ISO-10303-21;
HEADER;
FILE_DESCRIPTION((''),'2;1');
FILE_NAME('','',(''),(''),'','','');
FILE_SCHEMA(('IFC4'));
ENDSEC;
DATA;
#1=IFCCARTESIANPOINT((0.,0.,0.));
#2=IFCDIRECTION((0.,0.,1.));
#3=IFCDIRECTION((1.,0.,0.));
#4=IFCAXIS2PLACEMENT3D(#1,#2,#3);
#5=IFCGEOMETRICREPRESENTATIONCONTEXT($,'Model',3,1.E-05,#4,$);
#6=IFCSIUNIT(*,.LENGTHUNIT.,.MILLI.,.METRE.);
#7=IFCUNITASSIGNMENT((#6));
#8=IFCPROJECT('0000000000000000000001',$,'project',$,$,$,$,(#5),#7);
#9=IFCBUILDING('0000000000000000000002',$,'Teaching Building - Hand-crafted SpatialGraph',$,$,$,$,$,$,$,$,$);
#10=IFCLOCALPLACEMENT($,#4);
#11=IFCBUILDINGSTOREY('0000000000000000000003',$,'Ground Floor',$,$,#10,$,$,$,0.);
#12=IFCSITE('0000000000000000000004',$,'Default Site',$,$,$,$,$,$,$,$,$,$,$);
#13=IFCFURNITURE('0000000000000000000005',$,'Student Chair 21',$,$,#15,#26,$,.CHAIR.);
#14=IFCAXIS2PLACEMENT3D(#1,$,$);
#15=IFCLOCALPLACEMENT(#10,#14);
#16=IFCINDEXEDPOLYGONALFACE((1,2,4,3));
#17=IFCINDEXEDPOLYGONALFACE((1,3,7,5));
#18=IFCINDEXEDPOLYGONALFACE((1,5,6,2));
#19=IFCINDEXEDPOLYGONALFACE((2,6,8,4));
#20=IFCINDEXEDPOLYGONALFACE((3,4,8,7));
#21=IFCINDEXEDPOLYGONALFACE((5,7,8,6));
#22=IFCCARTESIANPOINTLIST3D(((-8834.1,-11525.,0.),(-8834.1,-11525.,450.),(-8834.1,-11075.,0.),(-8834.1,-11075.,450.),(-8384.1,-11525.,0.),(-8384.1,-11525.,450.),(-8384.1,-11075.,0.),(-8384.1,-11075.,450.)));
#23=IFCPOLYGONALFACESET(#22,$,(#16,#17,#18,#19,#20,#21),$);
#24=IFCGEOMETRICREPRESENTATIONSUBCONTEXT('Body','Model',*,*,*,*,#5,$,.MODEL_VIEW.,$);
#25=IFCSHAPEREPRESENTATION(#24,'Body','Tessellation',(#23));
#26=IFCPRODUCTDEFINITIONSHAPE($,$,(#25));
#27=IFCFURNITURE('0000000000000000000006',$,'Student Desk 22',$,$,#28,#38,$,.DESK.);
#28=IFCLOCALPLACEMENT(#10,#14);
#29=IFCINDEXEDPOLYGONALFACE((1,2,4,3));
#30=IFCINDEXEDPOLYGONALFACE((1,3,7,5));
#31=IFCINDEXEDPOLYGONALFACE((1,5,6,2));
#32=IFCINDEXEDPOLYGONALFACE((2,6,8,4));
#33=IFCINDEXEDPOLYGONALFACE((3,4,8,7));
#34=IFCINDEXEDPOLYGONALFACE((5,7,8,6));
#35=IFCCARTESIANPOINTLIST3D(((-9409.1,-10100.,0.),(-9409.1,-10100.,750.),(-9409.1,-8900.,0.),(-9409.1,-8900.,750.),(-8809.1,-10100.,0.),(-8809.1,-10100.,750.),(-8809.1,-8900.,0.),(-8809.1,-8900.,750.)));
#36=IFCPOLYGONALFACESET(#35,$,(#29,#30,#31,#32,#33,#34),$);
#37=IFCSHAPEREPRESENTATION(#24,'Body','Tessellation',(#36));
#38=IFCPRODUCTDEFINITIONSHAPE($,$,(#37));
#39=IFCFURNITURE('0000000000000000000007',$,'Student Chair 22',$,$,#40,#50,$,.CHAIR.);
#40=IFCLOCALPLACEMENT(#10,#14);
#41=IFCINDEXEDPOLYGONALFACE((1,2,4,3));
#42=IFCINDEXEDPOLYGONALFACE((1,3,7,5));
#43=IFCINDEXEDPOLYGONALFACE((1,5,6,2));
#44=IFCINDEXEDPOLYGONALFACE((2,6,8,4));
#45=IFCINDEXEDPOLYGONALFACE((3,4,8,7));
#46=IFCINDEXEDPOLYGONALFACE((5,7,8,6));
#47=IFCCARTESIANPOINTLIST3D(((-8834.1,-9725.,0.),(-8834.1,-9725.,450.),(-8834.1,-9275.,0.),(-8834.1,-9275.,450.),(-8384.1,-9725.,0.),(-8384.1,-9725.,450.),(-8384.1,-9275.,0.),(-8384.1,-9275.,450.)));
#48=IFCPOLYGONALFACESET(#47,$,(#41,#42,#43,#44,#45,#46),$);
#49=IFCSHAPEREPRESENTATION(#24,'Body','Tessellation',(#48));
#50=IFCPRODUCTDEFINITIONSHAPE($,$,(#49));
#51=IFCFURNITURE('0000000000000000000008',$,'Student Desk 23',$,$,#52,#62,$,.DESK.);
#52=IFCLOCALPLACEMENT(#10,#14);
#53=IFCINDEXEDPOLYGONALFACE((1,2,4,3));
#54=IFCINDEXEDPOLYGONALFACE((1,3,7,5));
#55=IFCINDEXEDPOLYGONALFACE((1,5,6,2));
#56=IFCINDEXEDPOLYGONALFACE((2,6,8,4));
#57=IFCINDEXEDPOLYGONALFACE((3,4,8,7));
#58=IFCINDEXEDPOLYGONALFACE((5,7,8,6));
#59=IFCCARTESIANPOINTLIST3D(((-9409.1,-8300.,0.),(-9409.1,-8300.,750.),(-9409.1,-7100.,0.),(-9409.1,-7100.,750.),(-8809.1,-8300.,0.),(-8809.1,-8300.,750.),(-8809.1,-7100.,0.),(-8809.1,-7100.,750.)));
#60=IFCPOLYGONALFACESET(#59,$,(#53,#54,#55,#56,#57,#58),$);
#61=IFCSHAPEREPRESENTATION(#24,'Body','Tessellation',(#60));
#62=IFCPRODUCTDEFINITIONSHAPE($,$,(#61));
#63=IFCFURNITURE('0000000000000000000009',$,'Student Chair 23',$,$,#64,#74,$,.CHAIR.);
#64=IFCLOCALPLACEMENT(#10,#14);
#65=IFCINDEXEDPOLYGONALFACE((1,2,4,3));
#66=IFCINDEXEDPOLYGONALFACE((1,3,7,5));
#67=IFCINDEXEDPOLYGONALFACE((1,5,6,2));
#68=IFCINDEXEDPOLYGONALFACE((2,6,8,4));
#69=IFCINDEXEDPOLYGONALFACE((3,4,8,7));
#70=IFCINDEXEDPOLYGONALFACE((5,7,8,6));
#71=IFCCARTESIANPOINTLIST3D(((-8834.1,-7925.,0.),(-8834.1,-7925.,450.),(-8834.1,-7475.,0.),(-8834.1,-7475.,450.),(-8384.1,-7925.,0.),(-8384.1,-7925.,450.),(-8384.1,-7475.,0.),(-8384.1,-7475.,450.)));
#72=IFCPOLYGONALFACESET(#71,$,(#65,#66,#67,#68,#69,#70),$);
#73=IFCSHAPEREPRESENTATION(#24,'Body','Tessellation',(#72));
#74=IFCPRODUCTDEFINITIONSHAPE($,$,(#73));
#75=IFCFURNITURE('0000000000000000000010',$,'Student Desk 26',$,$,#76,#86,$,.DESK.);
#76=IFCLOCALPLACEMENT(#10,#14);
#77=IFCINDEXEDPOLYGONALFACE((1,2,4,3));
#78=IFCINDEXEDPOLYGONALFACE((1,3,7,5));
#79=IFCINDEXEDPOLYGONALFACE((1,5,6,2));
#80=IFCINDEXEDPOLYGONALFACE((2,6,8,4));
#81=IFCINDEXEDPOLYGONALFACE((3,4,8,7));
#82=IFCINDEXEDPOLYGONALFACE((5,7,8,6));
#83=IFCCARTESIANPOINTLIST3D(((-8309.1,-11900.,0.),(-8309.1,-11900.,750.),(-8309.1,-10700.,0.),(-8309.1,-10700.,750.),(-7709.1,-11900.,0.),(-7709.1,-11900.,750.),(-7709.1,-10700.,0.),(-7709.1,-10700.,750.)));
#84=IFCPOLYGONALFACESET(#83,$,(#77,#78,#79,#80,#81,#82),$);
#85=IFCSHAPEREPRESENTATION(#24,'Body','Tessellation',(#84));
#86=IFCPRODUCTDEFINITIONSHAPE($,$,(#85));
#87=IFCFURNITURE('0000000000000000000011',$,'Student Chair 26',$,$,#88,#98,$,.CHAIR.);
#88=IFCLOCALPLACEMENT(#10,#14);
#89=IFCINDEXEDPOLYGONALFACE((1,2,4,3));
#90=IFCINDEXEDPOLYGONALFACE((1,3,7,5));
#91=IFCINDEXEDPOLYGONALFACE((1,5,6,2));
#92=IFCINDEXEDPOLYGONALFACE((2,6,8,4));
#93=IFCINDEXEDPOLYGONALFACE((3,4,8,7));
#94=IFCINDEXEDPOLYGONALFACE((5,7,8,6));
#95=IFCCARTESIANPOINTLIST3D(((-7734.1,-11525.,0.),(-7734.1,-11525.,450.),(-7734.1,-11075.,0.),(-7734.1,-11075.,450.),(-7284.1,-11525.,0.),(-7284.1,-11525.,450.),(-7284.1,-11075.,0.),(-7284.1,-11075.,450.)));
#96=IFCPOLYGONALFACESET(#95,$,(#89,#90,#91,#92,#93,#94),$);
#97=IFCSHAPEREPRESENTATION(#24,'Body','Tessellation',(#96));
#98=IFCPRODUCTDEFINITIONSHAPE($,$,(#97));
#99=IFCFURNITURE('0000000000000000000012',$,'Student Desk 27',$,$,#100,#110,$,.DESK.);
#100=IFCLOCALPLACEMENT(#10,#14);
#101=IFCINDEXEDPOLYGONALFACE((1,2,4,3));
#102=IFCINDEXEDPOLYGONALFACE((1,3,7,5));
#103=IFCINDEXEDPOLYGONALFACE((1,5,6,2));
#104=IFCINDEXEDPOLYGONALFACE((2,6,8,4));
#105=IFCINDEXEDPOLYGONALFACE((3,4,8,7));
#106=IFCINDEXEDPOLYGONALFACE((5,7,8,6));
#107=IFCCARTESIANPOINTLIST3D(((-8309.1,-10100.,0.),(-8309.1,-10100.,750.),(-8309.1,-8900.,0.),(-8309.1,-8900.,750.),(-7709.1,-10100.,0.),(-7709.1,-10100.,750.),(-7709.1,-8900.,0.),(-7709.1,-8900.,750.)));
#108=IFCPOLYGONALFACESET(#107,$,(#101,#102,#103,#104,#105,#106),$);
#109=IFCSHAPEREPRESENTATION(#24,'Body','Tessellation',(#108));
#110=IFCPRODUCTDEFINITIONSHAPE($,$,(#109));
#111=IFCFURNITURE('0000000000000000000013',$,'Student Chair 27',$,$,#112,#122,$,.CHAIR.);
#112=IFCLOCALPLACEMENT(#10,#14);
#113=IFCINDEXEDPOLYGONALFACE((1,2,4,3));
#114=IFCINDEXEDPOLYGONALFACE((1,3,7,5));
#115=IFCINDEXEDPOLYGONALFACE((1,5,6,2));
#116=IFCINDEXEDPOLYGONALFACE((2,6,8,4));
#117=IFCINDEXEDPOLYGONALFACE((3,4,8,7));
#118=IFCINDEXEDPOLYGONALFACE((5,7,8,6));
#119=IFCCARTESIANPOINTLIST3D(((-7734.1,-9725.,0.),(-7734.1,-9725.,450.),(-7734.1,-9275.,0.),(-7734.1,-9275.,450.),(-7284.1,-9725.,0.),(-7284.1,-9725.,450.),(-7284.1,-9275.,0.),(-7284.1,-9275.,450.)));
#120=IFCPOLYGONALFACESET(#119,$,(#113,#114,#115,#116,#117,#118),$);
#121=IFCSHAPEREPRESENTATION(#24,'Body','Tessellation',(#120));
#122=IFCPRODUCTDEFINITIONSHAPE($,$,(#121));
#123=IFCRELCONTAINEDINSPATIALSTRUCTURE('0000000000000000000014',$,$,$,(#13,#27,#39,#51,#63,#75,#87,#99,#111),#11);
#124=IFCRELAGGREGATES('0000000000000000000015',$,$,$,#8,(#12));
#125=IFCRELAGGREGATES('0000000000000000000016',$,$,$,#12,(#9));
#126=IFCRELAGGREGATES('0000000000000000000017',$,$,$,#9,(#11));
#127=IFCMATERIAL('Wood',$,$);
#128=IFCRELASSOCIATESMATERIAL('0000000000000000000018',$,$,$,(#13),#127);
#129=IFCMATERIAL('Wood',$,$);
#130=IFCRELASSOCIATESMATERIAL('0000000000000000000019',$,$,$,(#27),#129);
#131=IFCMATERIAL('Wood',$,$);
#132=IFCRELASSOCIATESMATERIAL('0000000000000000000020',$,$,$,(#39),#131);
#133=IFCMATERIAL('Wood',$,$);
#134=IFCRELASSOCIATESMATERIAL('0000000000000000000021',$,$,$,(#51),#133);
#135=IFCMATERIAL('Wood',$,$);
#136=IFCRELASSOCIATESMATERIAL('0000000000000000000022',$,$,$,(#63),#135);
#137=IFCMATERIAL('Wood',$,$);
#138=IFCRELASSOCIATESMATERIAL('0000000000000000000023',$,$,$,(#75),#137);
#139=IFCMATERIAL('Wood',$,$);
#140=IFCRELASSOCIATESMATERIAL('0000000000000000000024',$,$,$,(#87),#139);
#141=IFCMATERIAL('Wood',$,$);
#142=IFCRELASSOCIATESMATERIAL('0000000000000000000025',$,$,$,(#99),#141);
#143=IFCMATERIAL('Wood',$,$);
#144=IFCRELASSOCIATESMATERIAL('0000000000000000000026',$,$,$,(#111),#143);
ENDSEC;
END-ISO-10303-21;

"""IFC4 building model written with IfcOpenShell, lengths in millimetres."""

from ifc_helpers import new_model, si_unit, frame, origin_with_axes, origin_2d, place, context, subcontext, project, spatial, rectangle, extrude, material, element, save


model = new_model("IFC4")

# Units and contexts
model_context = context("Model", 3, precision=1e-05, world=origin_with_axes())
body_context = subcontext(model_context, "Body", "Model", "MODEL_VIEW")
ifc_project = project(units=[si_unit("LENGTHUNIT", "METRE", prefix="MILLI")], contexts=[model_context])

# Site, building, storey
site = spatial("IfcSite", under=ifc_project, Name="Default Site")
building = spatial("IfcBuilding", under=site, Name="Teaching Building - Hand-crafted SpatialGraph")
storey_placement = place(None, origin_with_axes())
storey = spatial("IfcBuildingStorey", under=building, at=storey_placement, Name="Ground Floor", Elevation=0.0)

# Furniture
ifc_material_1 = material(Name="Wood")
furniture_1_placement = place(storey_placement, frame((-8609.1, -11300.0, 0.0), z_axis=(0.0, 0.0, 1.0), x_axis=(1.0, 0.0, 0.0)))
element("IfcFurniture", 1, at=furniture_1_placement, inside=storey, material=ifc_material_1, Name="Student Chair 21", PredefinedType="CHAIR", context=body_context, shape_type="SweptSolid", body=[
    extrude(rectangle(XDim=450.0, YDim=450.0, at=origin_2d()), origin_with_axes(), (0.0, 0.0, 1.0), 450.0),
])
ifc_material_2 = material(Name="Wood")
furniture_2_placement = place(storey_placement, frame((-9109.1, -9500.0, 0.0), z_axis=(0.0, 0.0, 1.0), x_axis=(0.0, 1.0, 0.0)))
element("IfcFurniture", 2, at=furniture_2_placement, inside=storey, material=ifc_material_2, Name="Student Desk 22", PredefinedType="DESK", context=body_context, shape_type="SweptSolid", body=[
    extrude(rectangle(XDim=1200.0, YDim=600.0, at=origin_2d()), origin_with_axes(), (0.0, 0.0, 1.0), 750.0),
])
ifc_material_3 = material(Name="Wood")
furniture_3_placement = place(storey_placement, frame((-8609.1, -9500.0, 0.0), z_axis=(0.0, 0.0, 1.0), x_axis=(1.0, 0.0, 0.0)))
element("IfcFurniture", 3, at=furniture_3_placement, inside=storey, material=ifc_material_3, Name="Student Chair 22", PredefinedType="CHAIR", context=body_context, shape_type="SweptSolid", body=[
    extrude(rectangle(XDim=450.0, YDim=450.0, at=origin_2d()), origin_with_axes(), (0.0, 0.0, 1.0), 450.0),
])
ifc_material_4 = material(Name="Wood")
furniture_4_placement = place(storey_placement, frame((-9109.1, -7700.0, 0.0), z_axis=(0.0, 0.0, 1.0), x_axis=(0.0, 1.0, 0.0)))
element("IfcFurniture", 4, at=furniture_4_placement, inside=storey, material=ifc_material_4, Name="Student Desk 23", PredefinedType="DESK", context=body_context, shape_type="SweptSolid", body=[
    extrude(rectangle(XDim=1200.0, YDim=600.0, at=origin_2d()), origin_with_axes(), (0.0, 0.0, 1.0), 750.0),
])
ifc_material_5 = material(Name="Wood")
furniture_5_placement = place(storey_placement, frame((-8609.1, -7700.0, 0.0), z_axis=(0.0, 0.0, 1.0), x_axis=(1.0, 0.0, 0.0)))
element("IfcFurniture", 5, at=furniture_5_placement, inside=storey, material=ifc_material_5, Name="Student Chair 23", PredefinedType="CHAIR", context=body_context, shape_type="SweptSolid", body=[
    extrude(rectangle(XDim=450.0, YDim=450.0, at=origin_2d()), origin_with_axes(), (0.0, 0.0, 1.0), 450.0),
])
ifc_material_6 = material(Name="Wood")
furniture_6_placement = place(storey_placement, frame((-8009.1, -11300.0, 0.0), z_axis=(0.0, 0.0, 1.0), x_axis=(0.0, 1.0, 0.0)))
element("IfcFurniture", 6, at=furniture_6_placement, inside=storey, material=ifc_material_6, Name="Student Desk 26", PredefinedType="DESK", context=body_context, shape_type="SweptSolid", body=[
    extrude(rectangle(XDim=1200.0, YDim=600.0, at=origin_2d()), origin_with_axes(), (0.0, 0.0, 1.0), 750.0),
])
ifc_material_7 = material(Name="Wood")
furniture_7_placement = place(storey_placement, frame((-7509.1, -11300.0, 0.0), z_axis=(0.0, 0.0, 1.0), x_axis=(1.0, 0.0, 0.0)))
element("IfcFurniture", 7, at=furniture_7_placement, inside=storey, material=ifc_material_7, Name="Student Chair 26", PredefinedType="CHAIR", context=body_context, shape_type="SweptSolid", body=[
    extrude(rectangle(XDim=450.0, YDim=450.0, at=origin_2d()), origin_with_axes(), (0.0, 0.0, 1.0), 450.0),
])
ifc_material_8 = material(Name="Wood")
furniture_8_placement = place(storey_placement, frame((-8009.1, -9500.0, 0.0), z_axis=(0.0, 0.0, 1.0), x_axis=(0.0, 1.0, 0.0)))
element("IfcFurniture", 8, at=furniture_8_placement, inside=storey, material=ifc_material_8, Name="Student Desk 27", PredefinedType="DESK", context=body_context, shape_type="SweptSolid", body=[
    extrude(rectangle(XDim=1200.0, YDim=600.0, at=origin_2d()), origin_with_axes(), (0.0, 0.0, 1.0), 750.0),
])
ifc_material_9 = material(Name="Wood")
furniture_9_placement = place(storey_placement, frame((-7509.1, -9500.0, 0.0), z_axis=(0.0, 0.0, 1.0), x_axis=(1.0, 0.0, 0.0)))
element("IfcFurniture", 9, at=furniture_9_placement, inside=storey, material=ifc_material_9, Name="Student Chair 27", PredefinedType="CHAIR", context=body_context, shape_type="SweptSolid", body=[
    extrude(rectangle(XDim=450.0, YDim=450.0, at=origin_2d()), origin_with_axes(), (0.0, 0.0, 1.0), 450.0),
])

save(model, "model.ifc")
